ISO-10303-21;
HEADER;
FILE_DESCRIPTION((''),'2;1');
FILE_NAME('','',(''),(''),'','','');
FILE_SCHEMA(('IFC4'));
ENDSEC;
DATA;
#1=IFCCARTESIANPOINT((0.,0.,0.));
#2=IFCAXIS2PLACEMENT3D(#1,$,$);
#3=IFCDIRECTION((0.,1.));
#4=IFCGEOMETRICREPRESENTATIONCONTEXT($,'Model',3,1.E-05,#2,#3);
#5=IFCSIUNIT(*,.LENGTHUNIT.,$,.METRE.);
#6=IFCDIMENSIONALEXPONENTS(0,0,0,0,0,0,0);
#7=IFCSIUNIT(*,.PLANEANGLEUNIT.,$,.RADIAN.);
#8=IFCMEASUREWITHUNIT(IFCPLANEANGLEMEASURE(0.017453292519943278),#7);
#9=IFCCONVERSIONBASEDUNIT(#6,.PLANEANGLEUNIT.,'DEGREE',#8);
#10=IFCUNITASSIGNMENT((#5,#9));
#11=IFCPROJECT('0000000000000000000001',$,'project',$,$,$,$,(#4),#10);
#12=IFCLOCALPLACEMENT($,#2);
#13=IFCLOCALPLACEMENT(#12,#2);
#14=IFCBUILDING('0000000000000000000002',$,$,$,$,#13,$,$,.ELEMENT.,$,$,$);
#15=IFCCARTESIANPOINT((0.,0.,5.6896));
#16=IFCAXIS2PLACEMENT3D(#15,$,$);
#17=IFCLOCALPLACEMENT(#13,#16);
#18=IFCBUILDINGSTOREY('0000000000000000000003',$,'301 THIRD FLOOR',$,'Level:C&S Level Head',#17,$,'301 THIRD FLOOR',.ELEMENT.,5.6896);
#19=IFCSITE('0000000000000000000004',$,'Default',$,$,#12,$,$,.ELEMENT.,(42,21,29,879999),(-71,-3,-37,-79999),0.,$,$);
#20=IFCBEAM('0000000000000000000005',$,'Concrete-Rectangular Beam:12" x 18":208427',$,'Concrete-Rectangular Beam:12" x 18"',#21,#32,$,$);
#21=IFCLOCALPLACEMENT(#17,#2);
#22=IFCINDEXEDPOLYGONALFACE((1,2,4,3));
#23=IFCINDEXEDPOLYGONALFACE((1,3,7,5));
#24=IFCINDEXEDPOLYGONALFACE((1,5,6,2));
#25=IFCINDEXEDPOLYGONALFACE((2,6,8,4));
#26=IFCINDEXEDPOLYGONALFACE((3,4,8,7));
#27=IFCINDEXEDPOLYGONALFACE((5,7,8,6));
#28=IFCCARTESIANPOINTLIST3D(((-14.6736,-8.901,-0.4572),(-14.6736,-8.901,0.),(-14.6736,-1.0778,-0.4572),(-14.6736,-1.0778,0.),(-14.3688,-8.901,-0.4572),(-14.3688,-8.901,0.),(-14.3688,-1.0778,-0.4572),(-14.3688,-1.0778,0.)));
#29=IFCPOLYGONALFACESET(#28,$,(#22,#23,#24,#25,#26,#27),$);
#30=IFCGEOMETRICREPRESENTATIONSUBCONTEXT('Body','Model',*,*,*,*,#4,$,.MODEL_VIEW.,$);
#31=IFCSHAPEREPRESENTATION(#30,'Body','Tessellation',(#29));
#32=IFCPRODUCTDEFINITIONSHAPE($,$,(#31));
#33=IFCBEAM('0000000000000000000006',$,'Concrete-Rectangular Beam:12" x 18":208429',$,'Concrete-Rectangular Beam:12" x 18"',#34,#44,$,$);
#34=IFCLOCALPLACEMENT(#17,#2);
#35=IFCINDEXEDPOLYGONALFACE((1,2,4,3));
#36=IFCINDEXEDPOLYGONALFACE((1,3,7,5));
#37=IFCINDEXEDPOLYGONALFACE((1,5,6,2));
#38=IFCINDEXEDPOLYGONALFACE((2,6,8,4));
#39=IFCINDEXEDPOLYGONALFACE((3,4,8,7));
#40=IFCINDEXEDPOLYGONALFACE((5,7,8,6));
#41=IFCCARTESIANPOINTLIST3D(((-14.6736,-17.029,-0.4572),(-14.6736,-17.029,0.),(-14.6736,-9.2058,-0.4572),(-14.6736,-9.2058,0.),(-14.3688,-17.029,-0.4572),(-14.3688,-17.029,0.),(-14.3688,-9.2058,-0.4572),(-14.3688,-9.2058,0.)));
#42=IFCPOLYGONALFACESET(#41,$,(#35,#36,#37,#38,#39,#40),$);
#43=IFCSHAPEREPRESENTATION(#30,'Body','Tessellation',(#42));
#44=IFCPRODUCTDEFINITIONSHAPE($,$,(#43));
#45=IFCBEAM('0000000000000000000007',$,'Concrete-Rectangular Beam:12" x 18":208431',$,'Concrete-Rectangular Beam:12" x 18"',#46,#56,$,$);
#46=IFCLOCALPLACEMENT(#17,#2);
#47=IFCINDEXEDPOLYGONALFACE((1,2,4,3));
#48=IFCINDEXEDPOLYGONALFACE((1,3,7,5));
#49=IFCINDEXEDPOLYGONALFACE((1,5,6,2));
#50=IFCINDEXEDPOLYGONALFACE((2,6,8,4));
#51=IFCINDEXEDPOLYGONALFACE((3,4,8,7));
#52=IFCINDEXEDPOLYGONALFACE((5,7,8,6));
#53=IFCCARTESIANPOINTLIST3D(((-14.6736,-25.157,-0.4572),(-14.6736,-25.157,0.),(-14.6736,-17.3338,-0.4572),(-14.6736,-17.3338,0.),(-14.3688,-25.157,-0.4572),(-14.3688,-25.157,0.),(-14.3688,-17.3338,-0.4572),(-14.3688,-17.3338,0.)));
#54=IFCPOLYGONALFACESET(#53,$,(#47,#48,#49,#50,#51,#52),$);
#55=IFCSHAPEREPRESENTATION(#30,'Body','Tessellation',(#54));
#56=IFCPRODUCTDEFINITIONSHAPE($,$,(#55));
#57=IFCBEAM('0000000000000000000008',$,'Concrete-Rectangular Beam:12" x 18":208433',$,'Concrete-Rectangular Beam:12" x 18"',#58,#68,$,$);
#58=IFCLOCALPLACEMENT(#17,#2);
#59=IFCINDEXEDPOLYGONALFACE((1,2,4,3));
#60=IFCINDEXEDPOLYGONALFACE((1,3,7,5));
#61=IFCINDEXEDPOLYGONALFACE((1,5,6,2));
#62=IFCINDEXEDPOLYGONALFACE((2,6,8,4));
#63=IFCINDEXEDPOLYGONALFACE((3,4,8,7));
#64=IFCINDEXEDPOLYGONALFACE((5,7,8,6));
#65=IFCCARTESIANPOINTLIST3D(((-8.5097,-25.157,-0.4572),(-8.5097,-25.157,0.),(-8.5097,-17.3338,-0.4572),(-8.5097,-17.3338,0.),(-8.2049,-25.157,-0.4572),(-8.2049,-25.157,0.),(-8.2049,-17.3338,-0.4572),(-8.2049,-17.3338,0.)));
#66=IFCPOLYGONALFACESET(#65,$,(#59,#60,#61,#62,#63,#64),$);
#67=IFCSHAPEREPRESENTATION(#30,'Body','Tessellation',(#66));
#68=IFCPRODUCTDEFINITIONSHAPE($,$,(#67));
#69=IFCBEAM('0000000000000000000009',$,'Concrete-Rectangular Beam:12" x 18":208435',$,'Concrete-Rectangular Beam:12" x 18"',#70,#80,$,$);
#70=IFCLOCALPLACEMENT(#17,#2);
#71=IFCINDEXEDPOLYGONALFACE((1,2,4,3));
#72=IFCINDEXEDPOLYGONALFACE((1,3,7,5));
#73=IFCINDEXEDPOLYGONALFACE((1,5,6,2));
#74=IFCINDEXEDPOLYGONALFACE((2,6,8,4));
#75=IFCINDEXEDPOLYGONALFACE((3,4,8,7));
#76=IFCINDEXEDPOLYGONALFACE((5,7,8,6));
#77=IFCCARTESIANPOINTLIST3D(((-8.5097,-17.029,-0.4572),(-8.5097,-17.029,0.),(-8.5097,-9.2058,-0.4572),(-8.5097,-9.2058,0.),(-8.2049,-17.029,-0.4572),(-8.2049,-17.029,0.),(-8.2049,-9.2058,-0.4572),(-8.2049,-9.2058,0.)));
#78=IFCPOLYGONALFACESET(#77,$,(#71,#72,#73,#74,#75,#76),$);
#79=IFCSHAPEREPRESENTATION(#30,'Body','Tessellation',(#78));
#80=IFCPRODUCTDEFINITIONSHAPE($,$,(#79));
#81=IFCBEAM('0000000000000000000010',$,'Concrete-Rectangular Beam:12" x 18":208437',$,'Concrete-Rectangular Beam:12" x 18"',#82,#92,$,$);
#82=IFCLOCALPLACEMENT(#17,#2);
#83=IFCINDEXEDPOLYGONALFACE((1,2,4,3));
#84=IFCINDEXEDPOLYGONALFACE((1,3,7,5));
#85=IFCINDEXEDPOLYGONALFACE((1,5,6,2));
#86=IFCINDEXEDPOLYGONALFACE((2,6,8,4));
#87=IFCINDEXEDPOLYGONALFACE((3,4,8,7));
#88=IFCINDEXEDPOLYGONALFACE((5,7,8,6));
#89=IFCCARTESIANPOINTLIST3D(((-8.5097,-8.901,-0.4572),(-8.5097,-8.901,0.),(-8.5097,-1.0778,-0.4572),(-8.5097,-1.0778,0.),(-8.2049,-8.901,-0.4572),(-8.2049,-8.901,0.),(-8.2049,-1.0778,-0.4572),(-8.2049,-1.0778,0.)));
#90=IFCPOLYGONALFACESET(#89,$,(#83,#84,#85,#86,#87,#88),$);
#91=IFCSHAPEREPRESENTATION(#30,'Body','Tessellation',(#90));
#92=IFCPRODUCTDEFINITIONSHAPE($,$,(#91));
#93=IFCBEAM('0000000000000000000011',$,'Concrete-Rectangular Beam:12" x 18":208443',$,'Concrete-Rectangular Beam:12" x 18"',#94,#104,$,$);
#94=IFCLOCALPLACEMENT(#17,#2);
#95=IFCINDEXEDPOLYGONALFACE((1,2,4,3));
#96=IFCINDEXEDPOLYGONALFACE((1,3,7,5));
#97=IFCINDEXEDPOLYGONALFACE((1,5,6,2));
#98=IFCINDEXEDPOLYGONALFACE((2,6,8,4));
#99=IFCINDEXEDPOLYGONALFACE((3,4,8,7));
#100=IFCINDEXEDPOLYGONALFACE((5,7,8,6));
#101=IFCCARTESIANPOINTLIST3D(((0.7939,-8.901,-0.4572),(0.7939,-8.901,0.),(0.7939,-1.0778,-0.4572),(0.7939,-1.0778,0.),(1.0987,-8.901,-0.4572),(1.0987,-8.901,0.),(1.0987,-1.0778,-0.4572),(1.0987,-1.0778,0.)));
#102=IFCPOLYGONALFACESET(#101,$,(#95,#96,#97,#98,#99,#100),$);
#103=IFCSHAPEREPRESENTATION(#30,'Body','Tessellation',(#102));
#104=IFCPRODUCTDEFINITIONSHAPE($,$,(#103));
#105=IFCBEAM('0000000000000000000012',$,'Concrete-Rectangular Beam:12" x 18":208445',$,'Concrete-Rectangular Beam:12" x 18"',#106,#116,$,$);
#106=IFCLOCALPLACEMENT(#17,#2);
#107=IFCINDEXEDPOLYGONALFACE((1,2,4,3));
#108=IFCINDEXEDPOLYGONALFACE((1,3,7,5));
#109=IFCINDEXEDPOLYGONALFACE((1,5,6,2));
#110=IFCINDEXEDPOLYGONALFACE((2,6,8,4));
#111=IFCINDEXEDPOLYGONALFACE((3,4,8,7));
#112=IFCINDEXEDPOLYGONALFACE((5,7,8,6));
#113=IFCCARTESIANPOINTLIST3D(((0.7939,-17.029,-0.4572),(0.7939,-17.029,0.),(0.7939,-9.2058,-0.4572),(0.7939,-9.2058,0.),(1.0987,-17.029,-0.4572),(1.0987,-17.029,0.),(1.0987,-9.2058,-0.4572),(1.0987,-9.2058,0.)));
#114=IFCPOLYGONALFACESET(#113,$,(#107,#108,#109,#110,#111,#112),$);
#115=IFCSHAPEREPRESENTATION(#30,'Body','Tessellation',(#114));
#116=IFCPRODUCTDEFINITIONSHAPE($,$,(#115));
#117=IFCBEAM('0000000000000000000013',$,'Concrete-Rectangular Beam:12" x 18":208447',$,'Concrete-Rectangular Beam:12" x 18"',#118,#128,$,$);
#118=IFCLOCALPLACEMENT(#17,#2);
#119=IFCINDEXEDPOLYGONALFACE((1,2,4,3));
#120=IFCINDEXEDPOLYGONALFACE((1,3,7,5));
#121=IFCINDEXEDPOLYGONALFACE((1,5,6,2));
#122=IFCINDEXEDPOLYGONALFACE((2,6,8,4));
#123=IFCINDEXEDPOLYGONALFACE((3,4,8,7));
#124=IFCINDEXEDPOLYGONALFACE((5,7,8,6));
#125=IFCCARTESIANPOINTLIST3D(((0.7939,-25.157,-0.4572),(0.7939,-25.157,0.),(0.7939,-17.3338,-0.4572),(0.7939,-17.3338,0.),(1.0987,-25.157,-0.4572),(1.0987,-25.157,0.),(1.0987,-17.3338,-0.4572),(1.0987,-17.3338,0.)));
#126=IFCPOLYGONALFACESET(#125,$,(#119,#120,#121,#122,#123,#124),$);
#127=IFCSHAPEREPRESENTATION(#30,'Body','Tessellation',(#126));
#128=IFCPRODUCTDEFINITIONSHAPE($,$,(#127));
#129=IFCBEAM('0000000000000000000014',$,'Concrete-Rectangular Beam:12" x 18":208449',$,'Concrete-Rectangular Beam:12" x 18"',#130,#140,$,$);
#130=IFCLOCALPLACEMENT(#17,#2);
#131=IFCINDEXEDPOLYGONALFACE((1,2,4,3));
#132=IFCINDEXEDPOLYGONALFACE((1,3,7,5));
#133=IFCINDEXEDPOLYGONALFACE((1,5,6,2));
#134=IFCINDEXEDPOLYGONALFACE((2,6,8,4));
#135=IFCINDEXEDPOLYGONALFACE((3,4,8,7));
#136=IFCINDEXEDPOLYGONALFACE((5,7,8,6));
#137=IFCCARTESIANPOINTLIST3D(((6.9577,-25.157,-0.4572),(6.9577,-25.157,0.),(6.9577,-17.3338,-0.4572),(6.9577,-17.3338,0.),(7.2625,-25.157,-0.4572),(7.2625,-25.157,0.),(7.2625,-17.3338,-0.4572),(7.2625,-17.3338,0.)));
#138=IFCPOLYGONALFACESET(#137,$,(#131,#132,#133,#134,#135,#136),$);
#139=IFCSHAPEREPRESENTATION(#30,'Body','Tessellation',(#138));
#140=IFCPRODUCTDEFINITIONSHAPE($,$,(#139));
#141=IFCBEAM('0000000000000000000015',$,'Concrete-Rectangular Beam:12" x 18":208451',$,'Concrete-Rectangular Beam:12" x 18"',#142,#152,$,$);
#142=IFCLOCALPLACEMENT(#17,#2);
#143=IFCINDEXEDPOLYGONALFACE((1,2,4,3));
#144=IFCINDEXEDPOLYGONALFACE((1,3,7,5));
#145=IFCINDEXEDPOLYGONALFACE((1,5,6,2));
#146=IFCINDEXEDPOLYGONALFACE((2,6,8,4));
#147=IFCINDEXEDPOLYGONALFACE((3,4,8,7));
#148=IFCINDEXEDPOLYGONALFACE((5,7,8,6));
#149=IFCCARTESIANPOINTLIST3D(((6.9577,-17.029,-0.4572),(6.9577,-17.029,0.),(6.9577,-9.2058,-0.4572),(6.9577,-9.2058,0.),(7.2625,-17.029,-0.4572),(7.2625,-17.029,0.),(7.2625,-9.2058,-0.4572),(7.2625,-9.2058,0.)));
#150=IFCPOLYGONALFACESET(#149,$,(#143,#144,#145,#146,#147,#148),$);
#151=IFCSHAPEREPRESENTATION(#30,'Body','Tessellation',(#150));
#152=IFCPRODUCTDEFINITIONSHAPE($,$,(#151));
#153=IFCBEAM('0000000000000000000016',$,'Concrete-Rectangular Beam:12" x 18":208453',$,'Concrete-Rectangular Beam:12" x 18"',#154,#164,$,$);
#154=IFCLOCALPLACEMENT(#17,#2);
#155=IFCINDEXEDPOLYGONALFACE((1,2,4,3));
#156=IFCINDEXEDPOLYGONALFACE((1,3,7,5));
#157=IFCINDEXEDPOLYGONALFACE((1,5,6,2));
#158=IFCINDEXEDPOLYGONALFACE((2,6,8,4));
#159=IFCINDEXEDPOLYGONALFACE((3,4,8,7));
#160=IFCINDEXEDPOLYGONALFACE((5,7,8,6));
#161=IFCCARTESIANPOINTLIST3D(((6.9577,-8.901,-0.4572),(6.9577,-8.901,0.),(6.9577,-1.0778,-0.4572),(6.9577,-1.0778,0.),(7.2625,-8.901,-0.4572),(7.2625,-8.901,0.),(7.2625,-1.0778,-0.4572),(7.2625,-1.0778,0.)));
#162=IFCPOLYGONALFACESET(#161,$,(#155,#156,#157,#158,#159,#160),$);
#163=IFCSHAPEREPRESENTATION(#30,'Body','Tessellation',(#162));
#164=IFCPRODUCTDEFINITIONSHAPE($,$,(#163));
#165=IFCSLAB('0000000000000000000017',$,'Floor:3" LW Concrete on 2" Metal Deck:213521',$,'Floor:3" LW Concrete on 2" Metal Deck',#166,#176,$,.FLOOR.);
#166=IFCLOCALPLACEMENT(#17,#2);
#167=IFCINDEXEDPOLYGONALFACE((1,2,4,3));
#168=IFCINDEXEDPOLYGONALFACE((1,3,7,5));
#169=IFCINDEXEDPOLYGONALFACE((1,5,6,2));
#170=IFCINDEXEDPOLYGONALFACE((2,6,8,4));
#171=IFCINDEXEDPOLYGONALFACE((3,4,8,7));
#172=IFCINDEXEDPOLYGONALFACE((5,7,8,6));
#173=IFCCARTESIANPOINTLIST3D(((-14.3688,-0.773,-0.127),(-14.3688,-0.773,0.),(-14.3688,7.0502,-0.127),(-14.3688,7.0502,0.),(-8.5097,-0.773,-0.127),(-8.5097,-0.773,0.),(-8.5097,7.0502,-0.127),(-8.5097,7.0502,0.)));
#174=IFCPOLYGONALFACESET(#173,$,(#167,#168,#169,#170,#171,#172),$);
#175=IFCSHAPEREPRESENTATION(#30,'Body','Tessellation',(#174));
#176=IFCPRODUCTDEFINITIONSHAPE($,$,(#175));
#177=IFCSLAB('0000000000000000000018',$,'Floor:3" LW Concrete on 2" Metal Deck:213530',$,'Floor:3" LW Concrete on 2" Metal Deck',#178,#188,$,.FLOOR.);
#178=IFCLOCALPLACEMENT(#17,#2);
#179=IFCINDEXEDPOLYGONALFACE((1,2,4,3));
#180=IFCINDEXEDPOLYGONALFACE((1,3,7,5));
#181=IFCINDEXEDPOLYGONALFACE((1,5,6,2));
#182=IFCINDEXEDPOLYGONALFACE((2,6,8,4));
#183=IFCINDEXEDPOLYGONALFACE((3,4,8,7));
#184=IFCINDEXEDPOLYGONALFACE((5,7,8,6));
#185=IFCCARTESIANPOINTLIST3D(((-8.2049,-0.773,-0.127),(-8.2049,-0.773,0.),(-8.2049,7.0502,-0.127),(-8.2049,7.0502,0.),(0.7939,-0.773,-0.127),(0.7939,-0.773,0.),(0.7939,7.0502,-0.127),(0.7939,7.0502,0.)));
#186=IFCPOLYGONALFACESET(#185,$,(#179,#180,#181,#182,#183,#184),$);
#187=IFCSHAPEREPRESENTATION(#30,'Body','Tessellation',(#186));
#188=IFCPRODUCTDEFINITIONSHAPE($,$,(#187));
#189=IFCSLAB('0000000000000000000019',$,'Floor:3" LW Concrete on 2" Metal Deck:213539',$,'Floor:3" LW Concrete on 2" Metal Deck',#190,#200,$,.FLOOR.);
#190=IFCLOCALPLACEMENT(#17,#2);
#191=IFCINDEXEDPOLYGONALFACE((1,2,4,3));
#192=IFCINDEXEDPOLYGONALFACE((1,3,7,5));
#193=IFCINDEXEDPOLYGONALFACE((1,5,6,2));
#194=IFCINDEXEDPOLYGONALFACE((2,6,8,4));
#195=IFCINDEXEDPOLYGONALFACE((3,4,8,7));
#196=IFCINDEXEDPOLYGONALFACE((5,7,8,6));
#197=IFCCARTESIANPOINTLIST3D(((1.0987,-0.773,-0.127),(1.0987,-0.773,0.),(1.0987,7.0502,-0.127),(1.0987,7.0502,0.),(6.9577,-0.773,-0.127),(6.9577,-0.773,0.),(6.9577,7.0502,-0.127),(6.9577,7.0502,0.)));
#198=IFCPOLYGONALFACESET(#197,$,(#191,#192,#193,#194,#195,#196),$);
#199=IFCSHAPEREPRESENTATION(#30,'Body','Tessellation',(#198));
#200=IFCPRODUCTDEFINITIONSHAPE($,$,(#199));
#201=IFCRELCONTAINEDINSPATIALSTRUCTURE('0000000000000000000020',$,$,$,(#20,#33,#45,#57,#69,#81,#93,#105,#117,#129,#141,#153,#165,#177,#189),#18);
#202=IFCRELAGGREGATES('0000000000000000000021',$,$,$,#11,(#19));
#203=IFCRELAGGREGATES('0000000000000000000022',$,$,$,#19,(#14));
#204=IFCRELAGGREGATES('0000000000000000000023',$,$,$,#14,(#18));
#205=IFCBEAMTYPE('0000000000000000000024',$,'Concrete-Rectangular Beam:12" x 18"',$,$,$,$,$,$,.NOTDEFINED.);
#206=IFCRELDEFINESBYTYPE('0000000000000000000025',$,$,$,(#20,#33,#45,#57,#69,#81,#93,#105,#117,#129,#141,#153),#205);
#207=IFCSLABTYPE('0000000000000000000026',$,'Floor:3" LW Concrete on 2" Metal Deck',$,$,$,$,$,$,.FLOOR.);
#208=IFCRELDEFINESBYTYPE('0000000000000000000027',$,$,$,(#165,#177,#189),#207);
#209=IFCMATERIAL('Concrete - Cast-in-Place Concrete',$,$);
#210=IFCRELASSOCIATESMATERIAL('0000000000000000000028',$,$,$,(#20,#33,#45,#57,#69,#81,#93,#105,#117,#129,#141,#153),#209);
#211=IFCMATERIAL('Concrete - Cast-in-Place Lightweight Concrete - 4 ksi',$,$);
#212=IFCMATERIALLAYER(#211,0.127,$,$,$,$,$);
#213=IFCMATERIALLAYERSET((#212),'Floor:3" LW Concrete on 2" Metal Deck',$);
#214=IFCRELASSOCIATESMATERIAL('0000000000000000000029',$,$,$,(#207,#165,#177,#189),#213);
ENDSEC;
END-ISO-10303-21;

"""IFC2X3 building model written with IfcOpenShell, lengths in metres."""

from ifc_helpers import new_model, entity, si_unit, converted_unit, direction, frame, frame_2d, origin, origin_2d_with_axis, place, context, subcontext, project, spatial, rectangle, extrude, material, layer, layer_set, layer_usage, type_object, element, save


model = new_model("IFC2X3")

# Units and contexts
model_context = context("Model", 3, precision=1e-05, world=origin(), true_north=direction((0.0, 1.0)))
body_context = subcontext(model_context, "Body", "Model", "MODEL_VIEW")
ifc_project = project(units=[si_unit("LENGTHUNIT", "METRE"), converted_unit("PLANEANGLEUNIT", "DEGREE", entity("IfcPlaneAngleMeasure", 0.017453292519943278), si_unit("PLANEANGLEUNIT", "RADIAN"), dimensions=[0, 0, 0, 0, 0, 0, 0])], contexts=[model_context])

# Site, building, storey
site_placement = place(None, origin())
site = spatial("IfcSite", under=ifc_project, at=site_placement, Name="Default", CompositionType="ELEMENT", RefLatitude=(42, 21, 29, 879999), RefLongitude=(-71, -3, -37, -79999), RefElevation=0.0)
building_placement = place(site_placement, origin())
building = spatial("IfcBuilding", under=site, at=building_placement, CompositionType="ELEMENT")
storey_placement = place(building_placement, frame((0.0, 0.0, 5.6896)))
storey = spatial("IfcBuildingStorey", under=building, at=storey_placement, Name="301 THIRD FLOOR", ObjectType="Level:C&S Level Head", LongName="301 THIRD FLOOR", CompositionType="ELEMENT", Elevation=5.6896)

# Beams
ifc_material_1 = material(Name="Concrete - Cast-in-Place Concrete")
beam_type = type_object("IfcBeamType", Name="Concrete-Rectangular Beam:12\" x 18\"", PredefinedType="NOTDEFINED")
beam_1_placement = place(storey_placement, frame((-14.5212, -1.0778, 0.0), z_axis=(0.0, 0.0, 1.0), x_axis=(0.0, -1.0, 0.0)))
element("IfcBeam", 1, at=beam_1_placement, inside=storey, type_object=beam_type, material=ifc_material_1, Name="Concrete-Rectangular Beam:12\" x 18\":208427", ObjectType="Concrete-Rectangular Beam:12\" x 18\"", context=body_context, shape_type="SweptSolid", body=[
    extrude(rectangle(XDim=0.4572, YDim=0.3048, at=origin_2d_with_axis()), frame((0.0, 0.0, -0.2286), z_axis=(1.0, 0.0, 0.0), x_axis=(0.0, 0.0, -1.0)), (0.0, 0.0, 1.0), 7.8232),
])
beam_2_placement = place(storey_placement, frame((-14.5212, -9.2058, 0.0), z_axis=(0.0, 0.0, 1.0), x_axis=(0.0, -1.0, 0.0)))
element("IfcBeam", 2, at=beam_2_placement, inside=storey, type_object=beam_type, material=ifc_material_1, Name="Concrete-Rectangular Beam:12\" x 18\":208429", ObjectType="Concrete-Rectangular Beam:12\" x 18\"", context=body_context, shape_type="SweptSolid", body=[
    extrude(rectangle(XDim=0.4572, YDim=0.3048, at=origin_2d_with_axis()), frame((0.0, 0.0, -0.2286), z_axis=(1.0, 0.0, 0.0), x_axis=(0.0, 0.0, -1.0)), (0.0, 0.0, 1.0), 7.8232),
])
beam_3_placement = place(storey_placement, frame((-14.5212, -17.3338, 0.0), z_axis=(0.0, 0.0, 1.0), x_axis=(0.0, -1.0, 0.0)))
element("IfcBeam", 3, at=beam_3_placement, inside=storey, type_object=beam_type, material=ifc_material_1, Name="Concrete-Rectangular Beam:12\" x 18\":208431", ObjectType="Concrete-Rectangular Beam:12\" x 18\"", context=body_context, shape_type="SweptSolid", body=[
    extrude(rectangle(XDim=0.4572, YDim=0.3048, at=origin_2d_with_axis()), frame((0.0, 0.0, -0.2286), z_axis=(1.0, 0.0, 0.0), x_axis=(0.0, 0.0, -1.0)), (0.0, 0.0, 1.0), 7.8232),
])
beam_4_placement = place(storey_placement, frame((-8.3573, -17.3338, 0.0), z_axis=(0.0, 0.0, 1.0), x_axis=(0.0, -1.0, 0.0)))
element("IfcBeam", 4, at=beam_4_placement, inside=storey, type_object=beam_type, material=ifc_material_1, Name="Concrete-Rectangular Beam:12\" x 18\":208433", ObjectType="Concrete-Rectangular Beam:12\" x 18\"", context=body_context, shape_type="SweptSolid", body=[
    extrude(rectangle(XDim=0.4572, YDim=0.3048, at=frame_2d((0.0, 0.0), x_axis=(1.0, 0.0))), frame((0.0, 0.0, -0.2286), z_axis=(1.0, 0.0, 0.0), x_axis=(0.0, 0.0, -1.0)), (0.0, 0.0, 1.0), 7.8232),
])
for number, where, z_axis, x_axis, name in (
    (5, (-8.3573, -9.2058, 0.0), (0.0, 0.0, 1.0), (0.0, -1.0, 0.0), "Concrete-Rectangular Beam:12\" x 18\":208435"),
    (6, (-8.3573, -1.0778, 0.0), (0.0, 0.0, 1.0), (0.0, -1.0, 0.0), "Concrete-Rectangular Beam:12\" x 18\":208437"),
):
    element("IfcBeam", number, at=place(storey_placement, frame(where, z_axis=z_axis, x_axis=x_axis)), inside=storey, type_object=beam_type, material=ifc_material_1, Name=name, ObjectType="Concrete-Rectangular Beam:12\" x 18\"", context=body_context, shape_type="SweptSolid", body=[
        extrude(rectangle(XDim=0.4572, YDim=0.3048, at=frame_2d((0.0, 0.0), x_axis=(1.0, 0.0))), frame((0.0, 0.0, -0.2286), z_axis=(1.0, 0.0, 0.0), x_axis=(0.0, 0.0, -1.0)), (0.0, 0.0, 1.0), 7.8232),
    ])
for number, where, z_axis, x_axis, name in (
    (7, (0.9463, -1.0778, 0.0), (0.0, 0.0, 1.0), (0.0, -1.0, 0.0), "Concrete-Rectangular Beam:12\" x 18\":208443"),
    (8, (0.9463, -9.2058, 0.0), (0.0, 0.0, 1.0), (0.0, -1.0, 0.0), "Concrete-Rectangular Beam:12\" x 18\":208445"),
    (9, (0.9463, -17.3338, 0.0), (0.0, 0.0, 1.0), (0.0, -1.0, 0.0), "Concrete-Rectangular Beam:12\" x 18\":208447"),
):
    element("IfcBeam", number, at=place(storey_placement, frame(where, z_axis=z_axis, x_axis=x_axis)), inside=storey, type_object=beam_type, material=ifc_material_1, Name=name, ObjectType="Concrete-Rectangular Beam:12\" x 18\"", context=body_context, shape_type="SweptSolid", body=[
        extrude(rectangle(XDim=0.4572, YDim=0.3048, at=origin_2d_with_axis()), frame((0.0, 0.0, -0.2286), z_axis=(1.0, 0.0, 0.0), x_axis=(0.0, 0.0, -1.0)), (0.0, 0.0, 1.0), 7.8232),
    ])
beam_5_placement = place(storey_placement, frame((7.1101, -17.3338, 0.0), z_axis=(0.0, 0.0, 1.0), x_axis=(0.0, -1.0, 0.0)))
element("IfcBeam", 10, at=beam_5_placement, inside=storey, type_object=beam_type, material=ifc_material_1, Name="Concrete-Rectangular Beam:12\" x 18\":208449", ObjectType="Concrete-Rectangular Beam:12\" x 18\"", context=body_context, shape_type="SweptSolid", body=[
    extrude(rectangle(XDim=0.4572, YDim=0.3048, at=frame_2d((0.0, 0.0), x_axis=(1.0, 0.0))), frame((0.0, 0.0, -0.2286), z_axis=(1.0, 0.0, 0.0), x_axis=(0.0, 0.0, -1.0)), (0.0, 0.0, 1.0), 7.8232),
])
for number, where, z_axis, x_axis, name in (
    (11, (7.1101, -9.2058, 0.0), (0.0, 0.0, 1.0), (0.0, -1.0, 0.0), "Concrete-Rectangular Beam:12\" x 18\":208451"),
    (12, (7.1101, -1.0778, 0.0), (0.0, 0.0, 1.0), (0.0, -1.0, 0.0), "Concrete-Rectangular Beam:12\" x 18\":208453"),
):
    element("IfcBeam", number, at=place(storey_placement, frame(where, z_axis=z_axis, x_axis=x_axis)), inside=storey, type_object=beam_type, material=ifc_material_1, Name=name, ObjectType="Concrete-Rectangular Beam:12\" x 18\"", context=body_context, shape_type="SweptSolid", body=[
        extrude(rectangle(XDim=0.4572, YDim=0.3048, at=frame_2d((0.0, 0.0), x_axis=(1.0, 0.0))), frame((0.0, 0.0, -0.2286), z_axis=(1.0, 0.0, 0.0), x_axis=(0.0, 0.0, -1.0)), (0.0, 0.0, 1.0), 7.8232),
    ])

# Slabs
ifc_material_2 = material(Name="Concrete - Cast-in-Place Lightweight Concrete - 4 ksi")
ifc_layer = layer(ifc_material_2, 0.127)
ifc_layer_set = layer_set([ifc_layer], Name="Floor:3\" LW Concrete on 2\" Metal Deck")
ifc_layer_usage_1 = layer_usage(ifc_layer_set, "AXIS3", "POSITIVE", 0.0)
slab_type = type_object("IfcSlabType", Name="Floor:3\" LW Concrete on 2\" Metal Deck", PredefinedType="FLOOR", material=ifc_layer_set)
slab_1_placement = place(storey_placement, origin())
element("IfcSlab", 13, at=slab_1_placement, inside=storey, type_object=slab_type, material=ifc_layer_usage_1, Name="Floor:3\" LW Concrete on 2\" Metal Deck:213521", ObjectType="Floor:3\" LW Concrete on 2\" Metal Deck", PredefinedType="FLOOR", context=body_context, shape_type="SweptSolid", body=[
    extrude(rectangle(XDim=7.8232, YDim=5.859, at=frame_2d((0.0, 0.0), x_axis=(1.0, 0.0))), frame((-11.4393, 3.1386, 0.0), z_axis=(0.0, 0.0, -1.0), x_axis=(0.0, 1.0, 0.0)), (0.0, 0.0, 1.0), 0.127),
])
ifc_layer_usage_2 = layer_usage(ifc_layer_set, "AXIS3", "POSITIVE", 0.0)
slab_2_placement = place(storey_placement, origin())
element("IfcSlab", 14, at=slab_2_placement, inside=storey, type_object=slab_type, material=ifc_layer_usage_2, Name="Floor:3\" LW Concrete on 2\" Metal Deck:213530", ObjectType="Floor:3\" LW Concrete on 2\" Metal Deck", PredefinedType="FLOOR", context=body_context, shape_type="SweptSolid", body=[
    extrude(rectangle(XDim=7.8232, YDim=8.9988, at=origin_2d_with_axis()), frame((-3.7055, 3.1386, 0.0), z_axis=(0.0, 0.0, -1.0), x_axis=(0.0, 1.0, 0.0)), (0.0, 0.0, 1.0), 0.127),
])
ifc_layer_usage_3 = layer_usage(ifc_layer_set, "AXIS3", "POSITIVE", 0.0)
slab_3_placement = place(storey_placement, origin())
element("IfcSlab", 15, at=slab_3_placement, inside=storey, type_object=slab_type, material=ifc_layer_usage_3, Name="Floor:3\" LW Concrete on 2\" Metal Deck:213539", ObjectType="Floor:3\" LW Concrete on 2\" Metal Deck", PredefinedType="FLOOR", context=body_context, shape_type="SweptSolid", body=[
    extrude(rectangle(XDim=7.8232, YDim=5.859, at=origin_2d_with_axis()), frame((4.0282, 3.1386, 0.0), z_axis=(0.0, 0.0, -1.0), x_axis=(0.0, 1.0, 0.0)), (0.0, 0.0, 1.0), 0.127),
])

save(model, "model.ifc")
